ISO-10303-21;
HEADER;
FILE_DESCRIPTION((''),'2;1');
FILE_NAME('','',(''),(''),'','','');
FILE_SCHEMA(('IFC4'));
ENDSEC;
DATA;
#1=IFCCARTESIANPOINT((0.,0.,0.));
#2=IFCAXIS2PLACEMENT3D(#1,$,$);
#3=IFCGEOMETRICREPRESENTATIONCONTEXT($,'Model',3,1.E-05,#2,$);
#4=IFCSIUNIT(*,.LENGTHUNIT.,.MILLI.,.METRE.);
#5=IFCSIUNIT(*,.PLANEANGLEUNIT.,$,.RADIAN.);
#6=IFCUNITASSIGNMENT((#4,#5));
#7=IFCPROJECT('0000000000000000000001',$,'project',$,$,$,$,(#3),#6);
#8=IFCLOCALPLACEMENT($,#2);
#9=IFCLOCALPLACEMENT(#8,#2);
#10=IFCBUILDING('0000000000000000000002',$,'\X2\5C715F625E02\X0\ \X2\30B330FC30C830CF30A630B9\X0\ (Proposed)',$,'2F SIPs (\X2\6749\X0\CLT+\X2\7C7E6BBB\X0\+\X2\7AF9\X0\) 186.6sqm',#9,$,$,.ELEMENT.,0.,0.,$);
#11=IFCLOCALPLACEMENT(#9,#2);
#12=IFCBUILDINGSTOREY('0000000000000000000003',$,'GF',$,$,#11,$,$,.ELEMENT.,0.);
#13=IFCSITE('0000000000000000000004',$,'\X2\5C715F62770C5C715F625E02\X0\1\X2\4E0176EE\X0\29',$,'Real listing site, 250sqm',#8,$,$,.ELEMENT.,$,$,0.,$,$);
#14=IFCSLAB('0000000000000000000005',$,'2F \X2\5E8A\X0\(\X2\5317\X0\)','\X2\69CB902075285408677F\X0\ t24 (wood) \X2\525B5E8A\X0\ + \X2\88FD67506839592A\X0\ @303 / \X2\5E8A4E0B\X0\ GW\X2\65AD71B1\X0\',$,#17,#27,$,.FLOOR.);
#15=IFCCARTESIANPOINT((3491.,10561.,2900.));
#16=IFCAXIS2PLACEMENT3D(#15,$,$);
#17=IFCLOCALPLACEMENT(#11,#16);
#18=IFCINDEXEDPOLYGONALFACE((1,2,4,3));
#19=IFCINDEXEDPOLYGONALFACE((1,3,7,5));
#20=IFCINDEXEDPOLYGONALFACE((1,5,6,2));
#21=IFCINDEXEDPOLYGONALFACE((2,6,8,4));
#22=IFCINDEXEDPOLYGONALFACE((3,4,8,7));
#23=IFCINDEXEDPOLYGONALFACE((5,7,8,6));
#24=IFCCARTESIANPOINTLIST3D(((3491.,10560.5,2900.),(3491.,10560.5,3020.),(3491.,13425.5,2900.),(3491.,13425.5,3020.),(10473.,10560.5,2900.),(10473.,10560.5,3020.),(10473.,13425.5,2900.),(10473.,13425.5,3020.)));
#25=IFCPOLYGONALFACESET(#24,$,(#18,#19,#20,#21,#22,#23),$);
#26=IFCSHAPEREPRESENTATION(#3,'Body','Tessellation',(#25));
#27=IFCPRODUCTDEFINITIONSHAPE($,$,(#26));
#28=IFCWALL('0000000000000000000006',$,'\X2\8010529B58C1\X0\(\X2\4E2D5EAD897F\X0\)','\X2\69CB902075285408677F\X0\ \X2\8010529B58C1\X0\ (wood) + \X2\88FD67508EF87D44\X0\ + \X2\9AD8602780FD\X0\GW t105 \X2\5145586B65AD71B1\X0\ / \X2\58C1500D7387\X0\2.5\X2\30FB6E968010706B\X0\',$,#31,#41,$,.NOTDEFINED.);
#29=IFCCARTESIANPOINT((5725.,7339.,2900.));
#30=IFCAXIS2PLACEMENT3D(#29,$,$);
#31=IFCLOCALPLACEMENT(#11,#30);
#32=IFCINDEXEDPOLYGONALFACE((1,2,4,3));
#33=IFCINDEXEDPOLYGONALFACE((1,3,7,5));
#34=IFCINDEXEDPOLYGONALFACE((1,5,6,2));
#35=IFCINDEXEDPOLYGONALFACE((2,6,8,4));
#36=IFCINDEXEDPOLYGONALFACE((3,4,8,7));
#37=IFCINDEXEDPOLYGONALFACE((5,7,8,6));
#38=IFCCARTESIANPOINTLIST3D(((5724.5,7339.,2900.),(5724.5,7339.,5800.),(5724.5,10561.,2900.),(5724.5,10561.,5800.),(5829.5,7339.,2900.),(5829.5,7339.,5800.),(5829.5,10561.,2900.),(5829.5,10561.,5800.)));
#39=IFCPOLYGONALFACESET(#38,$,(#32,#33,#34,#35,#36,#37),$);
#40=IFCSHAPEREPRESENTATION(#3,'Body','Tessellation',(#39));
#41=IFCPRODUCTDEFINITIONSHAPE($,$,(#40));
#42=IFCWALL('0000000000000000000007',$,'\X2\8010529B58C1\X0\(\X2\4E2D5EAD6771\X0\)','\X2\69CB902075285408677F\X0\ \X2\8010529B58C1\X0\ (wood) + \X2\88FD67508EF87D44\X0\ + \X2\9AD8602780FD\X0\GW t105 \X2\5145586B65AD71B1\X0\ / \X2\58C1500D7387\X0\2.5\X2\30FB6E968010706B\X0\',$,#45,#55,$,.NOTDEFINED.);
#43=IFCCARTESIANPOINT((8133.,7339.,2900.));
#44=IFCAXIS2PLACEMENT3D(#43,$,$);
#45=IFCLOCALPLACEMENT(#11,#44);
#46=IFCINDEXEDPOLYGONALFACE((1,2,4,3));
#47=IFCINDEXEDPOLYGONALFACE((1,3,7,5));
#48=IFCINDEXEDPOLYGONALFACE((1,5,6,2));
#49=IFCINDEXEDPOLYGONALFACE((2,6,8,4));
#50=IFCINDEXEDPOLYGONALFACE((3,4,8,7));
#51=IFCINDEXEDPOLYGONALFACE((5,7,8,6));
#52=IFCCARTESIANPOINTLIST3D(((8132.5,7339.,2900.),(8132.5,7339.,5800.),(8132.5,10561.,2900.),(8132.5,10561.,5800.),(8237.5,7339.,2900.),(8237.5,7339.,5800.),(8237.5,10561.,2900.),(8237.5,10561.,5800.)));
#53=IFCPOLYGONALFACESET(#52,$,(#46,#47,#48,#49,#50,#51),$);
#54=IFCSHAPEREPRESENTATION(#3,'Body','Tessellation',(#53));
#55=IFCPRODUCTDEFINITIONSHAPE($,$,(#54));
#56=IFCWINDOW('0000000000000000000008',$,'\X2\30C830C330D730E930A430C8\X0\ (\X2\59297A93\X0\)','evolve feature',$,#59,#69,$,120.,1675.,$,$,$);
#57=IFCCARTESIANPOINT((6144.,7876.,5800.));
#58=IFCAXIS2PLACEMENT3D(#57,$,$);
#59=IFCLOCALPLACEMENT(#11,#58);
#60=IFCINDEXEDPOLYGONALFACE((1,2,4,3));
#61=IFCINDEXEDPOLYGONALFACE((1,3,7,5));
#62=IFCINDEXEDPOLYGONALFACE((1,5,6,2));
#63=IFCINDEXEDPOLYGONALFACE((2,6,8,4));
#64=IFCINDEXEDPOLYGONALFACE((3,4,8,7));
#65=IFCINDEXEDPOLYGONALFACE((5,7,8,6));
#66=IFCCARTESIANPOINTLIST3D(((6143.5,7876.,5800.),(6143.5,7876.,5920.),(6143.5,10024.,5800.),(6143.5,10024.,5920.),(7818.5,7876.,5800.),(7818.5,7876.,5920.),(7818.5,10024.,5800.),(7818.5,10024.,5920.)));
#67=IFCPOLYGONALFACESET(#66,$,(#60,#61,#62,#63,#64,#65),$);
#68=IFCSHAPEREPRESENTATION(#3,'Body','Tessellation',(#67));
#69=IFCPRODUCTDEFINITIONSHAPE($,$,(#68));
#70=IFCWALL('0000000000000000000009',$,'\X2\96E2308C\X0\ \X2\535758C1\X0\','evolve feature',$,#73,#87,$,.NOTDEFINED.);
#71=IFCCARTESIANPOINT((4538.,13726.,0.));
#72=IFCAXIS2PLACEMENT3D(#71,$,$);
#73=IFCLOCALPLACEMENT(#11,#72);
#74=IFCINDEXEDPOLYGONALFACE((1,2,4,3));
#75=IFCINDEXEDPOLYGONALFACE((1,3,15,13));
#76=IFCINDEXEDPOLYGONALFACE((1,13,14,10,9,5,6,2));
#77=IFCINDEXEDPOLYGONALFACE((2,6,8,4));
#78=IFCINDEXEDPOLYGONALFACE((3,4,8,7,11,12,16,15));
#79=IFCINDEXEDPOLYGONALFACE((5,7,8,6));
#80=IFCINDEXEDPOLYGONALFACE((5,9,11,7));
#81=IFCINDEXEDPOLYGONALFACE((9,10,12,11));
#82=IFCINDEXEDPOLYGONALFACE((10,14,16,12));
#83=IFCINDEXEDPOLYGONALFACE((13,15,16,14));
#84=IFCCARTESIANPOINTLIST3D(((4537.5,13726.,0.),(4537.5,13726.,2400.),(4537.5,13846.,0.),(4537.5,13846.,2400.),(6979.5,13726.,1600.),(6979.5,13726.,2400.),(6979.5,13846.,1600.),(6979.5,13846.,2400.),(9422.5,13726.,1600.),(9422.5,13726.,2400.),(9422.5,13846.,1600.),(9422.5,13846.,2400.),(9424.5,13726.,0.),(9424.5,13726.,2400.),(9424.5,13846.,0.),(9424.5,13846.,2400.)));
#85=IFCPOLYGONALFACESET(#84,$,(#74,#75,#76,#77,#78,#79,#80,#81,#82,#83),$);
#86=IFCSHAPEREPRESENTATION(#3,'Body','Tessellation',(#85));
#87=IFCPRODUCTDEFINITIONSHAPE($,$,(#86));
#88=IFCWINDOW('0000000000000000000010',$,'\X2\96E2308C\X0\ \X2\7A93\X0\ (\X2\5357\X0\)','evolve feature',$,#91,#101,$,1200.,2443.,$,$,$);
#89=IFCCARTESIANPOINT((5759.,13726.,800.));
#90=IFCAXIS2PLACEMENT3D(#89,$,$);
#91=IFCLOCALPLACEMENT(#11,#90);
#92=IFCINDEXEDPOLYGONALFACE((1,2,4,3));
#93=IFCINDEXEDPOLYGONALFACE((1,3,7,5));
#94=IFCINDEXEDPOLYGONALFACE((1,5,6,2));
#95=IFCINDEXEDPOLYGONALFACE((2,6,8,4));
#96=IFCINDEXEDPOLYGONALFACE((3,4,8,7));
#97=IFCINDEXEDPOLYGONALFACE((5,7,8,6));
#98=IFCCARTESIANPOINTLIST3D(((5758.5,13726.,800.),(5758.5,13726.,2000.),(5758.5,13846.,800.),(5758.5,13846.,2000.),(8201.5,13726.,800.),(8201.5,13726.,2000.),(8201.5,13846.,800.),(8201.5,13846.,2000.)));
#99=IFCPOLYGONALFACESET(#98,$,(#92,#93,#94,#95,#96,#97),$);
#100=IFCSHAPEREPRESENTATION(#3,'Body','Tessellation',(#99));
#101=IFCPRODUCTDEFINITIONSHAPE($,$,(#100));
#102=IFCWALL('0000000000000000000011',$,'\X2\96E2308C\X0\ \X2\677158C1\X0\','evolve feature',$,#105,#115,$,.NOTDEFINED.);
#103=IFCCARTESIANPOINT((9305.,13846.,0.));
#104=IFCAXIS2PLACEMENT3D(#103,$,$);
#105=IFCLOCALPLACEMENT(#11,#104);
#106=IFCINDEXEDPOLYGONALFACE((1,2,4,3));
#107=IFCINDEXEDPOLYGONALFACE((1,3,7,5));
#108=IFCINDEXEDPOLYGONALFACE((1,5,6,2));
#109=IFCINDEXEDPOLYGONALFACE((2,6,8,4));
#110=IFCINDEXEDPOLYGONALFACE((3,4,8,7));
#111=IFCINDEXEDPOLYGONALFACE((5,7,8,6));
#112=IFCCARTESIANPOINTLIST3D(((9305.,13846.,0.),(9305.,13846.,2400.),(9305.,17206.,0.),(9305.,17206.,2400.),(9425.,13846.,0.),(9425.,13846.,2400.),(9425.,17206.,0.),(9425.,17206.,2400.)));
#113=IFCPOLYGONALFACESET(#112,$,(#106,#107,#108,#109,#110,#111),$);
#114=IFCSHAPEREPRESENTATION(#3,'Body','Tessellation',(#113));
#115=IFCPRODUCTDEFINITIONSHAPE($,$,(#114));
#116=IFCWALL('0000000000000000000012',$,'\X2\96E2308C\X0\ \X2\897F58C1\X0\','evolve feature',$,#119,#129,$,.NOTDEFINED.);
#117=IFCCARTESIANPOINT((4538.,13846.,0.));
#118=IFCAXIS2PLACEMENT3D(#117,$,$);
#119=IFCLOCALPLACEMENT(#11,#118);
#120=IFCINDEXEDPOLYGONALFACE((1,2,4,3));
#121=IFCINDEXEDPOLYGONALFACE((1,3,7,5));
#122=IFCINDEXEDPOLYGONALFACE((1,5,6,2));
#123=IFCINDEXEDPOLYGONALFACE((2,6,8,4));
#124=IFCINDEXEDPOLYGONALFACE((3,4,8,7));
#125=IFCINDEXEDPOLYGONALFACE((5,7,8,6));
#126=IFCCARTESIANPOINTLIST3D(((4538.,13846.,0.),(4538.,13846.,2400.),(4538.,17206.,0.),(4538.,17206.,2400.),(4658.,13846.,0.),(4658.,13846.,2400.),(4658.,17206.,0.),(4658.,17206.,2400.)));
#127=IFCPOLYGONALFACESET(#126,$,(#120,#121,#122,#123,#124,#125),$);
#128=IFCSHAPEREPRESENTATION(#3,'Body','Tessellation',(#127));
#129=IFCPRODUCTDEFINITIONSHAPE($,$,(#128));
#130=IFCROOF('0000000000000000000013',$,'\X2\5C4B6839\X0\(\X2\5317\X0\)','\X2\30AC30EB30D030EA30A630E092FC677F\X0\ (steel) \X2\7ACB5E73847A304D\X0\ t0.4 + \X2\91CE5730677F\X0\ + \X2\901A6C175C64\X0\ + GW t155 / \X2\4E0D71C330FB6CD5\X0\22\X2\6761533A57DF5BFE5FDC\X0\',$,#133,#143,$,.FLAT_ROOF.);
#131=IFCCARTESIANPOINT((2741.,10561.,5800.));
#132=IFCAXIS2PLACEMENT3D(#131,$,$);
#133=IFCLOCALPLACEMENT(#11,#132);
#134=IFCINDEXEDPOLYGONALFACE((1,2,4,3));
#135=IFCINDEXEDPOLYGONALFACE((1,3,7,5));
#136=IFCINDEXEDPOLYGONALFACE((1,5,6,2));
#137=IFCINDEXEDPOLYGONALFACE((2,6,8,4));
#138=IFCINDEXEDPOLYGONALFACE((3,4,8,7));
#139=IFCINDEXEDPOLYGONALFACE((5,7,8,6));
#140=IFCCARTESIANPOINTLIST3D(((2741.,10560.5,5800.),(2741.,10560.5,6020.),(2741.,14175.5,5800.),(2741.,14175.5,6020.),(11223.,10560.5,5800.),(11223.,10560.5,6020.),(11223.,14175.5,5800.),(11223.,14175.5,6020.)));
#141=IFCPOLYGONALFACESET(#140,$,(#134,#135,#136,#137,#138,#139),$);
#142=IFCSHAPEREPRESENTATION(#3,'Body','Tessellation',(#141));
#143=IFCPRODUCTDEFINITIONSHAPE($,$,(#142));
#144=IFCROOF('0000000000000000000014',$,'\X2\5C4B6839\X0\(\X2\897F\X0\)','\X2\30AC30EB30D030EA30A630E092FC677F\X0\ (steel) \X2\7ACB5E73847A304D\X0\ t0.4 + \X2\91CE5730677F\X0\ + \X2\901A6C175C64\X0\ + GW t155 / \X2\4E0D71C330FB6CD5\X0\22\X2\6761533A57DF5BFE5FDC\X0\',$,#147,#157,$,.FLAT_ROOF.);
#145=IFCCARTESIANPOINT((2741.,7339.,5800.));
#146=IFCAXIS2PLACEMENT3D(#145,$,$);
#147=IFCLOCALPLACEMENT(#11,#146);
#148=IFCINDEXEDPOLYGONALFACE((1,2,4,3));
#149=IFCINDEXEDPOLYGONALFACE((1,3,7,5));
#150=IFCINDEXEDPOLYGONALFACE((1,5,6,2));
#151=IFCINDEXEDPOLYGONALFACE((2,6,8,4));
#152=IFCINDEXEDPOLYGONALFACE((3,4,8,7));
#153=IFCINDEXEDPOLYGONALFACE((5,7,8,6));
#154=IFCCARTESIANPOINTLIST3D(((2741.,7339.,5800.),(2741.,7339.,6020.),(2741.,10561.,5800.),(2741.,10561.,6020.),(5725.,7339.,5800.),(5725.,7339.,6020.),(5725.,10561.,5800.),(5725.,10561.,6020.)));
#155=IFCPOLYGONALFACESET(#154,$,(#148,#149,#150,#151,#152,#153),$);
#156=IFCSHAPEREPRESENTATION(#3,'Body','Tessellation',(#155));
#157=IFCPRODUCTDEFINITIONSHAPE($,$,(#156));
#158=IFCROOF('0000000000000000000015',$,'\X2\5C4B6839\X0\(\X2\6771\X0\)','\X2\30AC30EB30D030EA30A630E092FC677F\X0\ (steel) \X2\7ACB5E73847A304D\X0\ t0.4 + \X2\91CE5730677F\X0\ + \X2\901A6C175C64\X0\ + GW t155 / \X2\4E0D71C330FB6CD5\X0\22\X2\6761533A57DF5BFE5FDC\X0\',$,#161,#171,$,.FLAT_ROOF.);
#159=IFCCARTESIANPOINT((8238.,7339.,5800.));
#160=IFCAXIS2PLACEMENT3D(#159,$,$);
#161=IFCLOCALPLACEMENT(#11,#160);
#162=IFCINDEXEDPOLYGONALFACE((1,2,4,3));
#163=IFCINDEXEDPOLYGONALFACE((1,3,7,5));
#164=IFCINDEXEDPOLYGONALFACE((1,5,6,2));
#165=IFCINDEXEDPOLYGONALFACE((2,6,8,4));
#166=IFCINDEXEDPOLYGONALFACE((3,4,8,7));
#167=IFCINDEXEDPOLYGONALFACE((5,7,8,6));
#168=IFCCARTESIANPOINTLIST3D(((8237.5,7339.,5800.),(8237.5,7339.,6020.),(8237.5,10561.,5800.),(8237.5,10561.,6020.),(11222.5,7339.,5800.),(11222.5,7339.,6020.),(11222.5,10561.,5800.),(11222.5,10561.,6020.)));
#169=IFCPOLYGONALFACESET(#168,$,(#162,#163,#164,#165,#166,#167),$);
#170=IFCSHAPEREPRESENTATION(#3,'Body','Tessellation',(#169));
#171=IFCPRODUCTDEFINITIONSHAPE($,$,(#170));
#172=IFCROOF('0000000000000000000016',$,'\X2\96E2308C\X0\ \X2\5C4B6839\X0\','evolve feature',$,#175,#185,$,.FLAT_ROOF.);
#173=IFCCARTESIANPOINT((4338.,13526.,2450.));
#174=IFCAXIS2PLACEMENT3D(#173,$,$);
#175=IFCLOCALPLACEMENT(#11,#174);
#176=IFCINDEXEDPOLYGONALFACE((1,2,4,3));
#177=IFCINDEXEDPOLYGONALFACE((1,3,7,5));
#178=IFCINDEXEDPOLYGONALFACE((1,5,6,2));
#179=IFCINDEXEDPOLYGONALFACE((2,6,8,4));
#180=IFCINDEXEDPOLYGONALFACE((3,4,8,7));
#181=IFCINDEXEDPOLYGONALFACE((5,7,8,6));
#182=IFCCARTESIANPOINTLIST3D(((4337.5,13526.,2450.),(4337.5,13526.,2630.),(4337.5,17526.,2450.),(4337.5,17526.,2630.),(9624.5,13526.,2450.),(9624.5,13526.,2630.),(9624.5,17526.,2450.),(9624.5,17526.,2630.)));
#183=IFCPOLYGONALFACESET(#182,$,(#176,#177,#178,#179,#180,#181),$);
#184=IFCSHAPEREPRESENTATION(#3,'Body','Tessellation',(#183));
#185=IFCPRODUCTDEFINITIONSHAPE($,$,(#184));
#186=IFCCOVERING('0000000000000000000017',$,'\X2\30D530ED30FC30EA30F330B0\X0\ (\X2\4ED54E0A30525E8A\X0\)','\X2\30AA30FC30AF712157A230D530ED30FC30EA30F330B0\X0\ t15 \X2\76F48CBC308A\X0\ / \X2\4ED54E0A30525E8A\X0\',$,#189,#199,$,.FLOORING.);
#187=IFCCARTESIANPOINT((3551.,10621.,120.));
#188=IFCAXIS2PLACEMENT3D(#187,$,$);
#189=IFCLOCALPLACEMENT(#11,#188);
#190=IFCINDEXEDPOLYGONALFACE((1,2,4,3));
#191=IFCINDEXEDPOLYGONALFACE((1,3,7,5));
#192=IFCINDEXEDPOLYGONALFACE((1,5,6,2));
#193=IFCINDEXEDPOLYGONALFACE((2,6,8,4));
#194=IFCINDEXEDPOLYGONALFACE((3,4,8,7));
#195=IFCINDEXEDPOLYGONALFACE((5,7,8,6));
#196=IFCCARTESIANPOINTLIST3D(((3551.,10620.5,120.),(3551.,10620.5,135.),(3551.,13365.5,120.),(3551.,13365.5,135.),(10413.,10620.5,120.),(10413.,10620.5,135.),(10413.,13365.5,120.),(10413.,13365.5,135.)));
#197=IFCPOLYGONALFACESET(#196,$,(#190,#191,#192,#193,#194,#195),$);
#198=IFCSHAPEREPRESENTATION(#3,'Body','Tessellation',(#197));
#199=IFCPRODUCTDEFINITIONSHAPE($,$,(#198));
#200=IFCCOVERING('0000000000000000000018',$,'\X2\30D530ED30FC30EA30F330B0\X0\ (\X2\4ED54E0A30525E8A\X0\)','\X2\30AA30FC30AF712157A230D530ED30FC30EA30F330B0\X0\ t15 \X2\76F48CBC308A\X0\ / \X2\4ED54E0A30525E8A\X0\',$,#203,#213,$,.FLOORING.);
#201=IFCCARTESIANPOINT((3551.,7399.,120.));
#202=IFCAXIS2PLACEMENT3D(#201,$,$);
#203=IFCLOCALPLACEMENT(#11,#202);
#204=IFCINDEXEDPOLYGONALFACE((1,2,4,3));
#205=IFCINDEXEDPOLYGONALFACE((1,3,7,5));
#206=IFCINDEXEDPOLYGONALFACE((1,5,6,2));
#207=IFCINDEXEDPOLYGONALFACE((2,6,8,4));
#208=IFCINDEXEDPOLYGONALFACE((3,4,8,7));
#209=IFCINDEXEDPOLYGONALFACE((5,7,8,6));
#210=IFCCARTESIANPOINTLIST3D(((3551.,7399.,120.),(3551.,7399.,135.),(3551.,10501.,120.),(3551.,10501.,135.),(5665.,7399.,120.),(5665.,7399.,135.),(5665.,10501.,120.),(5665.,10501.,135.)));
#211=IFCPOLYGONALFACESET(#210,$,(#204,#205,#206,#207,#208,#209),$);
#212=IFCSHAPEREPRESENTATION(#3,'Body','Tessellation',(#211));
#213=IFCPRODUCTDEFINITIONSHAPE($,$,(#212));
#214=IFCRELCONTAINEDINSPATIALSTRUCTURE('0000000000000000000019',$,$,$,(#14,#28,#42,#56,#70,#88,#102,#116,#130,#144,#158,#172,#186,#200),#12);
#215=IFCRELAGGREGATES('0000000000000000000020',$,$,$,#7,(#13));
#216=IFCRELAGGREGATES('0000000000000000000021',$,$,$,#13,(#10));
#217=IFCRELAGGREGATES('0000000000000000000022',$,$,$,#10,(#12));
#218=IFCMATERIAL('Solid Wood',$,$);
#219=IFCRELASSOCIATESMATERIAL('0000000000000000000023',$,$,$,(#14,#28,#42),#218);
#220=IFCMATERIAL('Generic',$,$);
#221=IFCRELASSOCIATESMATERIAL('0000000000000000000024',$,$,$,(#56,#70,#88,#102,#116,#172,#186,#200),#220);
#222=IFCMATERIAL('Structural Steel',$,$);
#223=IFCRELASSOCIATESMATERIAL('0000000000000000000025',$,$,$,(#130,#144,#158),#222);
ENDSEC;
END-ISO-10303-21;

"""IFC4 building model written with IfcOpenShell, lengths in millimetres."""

from ifc_helpers import new_model, si_unit, frame, frame_2d, origin, place, context, project, spatial, rectangle, extrude, material, element, fill, save


model = new_model("IFC4")

# Units and contexts
model_context = context("Model", 3, precision=1e-05, world=origin())
ifc_project = project(units=[si_unit("LENGTHUNIT", "METRE", prefix="MILLI"), si_unit("PLANEANGLEUNIT", "RADIAN")], contexts=[model_context])

# Site, building, storey
site_placement = place(None, origin())
site = spatial("IfcSite", under=ifc_project, at=site_placement, Name="山形県山形市1丁目29", ObjectType="Real listing site, 250sqm", CompositionType="ELEMENT", RefElevation=0.0)
building_placement = place(site_placement, origin())
building = spatial("IfcBuilding", under=site, at=building_placement, Name="山形市 コートハウス (Proposed)", ObjectType="2F SIPs (杉CLT+籾殻+竹) 186.6sqm", CompositionType="ELEMENT", ElevationOfRefHeight=0.0, ElevationOfTerrain=0.0)
storey_placement = place(building_placement, origin())
storey = spatial("IfcBuildingStorey", under=building, at=storey_placement, Name="GF", CompositionType="ELEMENT", Elevation=0.0)

# Slab
ifc_material_1 = material(Name="Solid Wood")
slab_1_placement = place(storey_placement, frame((3491.0, 10561.0, 2900.0)))
element("IfcSlab", 1, at=slab_1_placement, inside=storey, material=ifc_material_1, Name="2F 床(北)", Description="構造用合板 t24 (wood) 剛床 + 製材根太 @303 / 床下 GW断熱", PredefinedType="FLOOR", context=model_context, shape_type="SweptSolid", body=[
    extrude(rectangle(XDim=6982.0, YDim=2865.0, at=frame_2d((3491.0, 1432.0))), frame((3491.0, 10561.0, 2900.0)), (0.0, 0.0, 1.0), 120.0),
])
ifc_material_2 = material(Name="Generic")

# Walls
wall_1_placement = place(storey_placement, frame((5725.0, 7339.0, 2900.0)))
element("IfcWall", 2, at=wall_1_placement, inside=storey, material=ifc_material_1, Name="耐力壁(中庭西)", Description="構造用合板 耐力壁 (wood) + 製材軸組 + 高性能GW t105 充填断熱 / 壁倍率2.5・準耐火", PredefinedType="NOTDEFINED", context=model_context, shape_type="SweptSolid", body=[
    extrude(rectangle(XDim=105.0, YDim=3222.0, at=frame_2d((52.0, 1611.0))), frame((5725.0, 7339.0, 2900.0)), (0.0, 0.0, 1.0), 2900.0),
])
wall_2_placement = place(storey_placement, frame((8133.0, 7339.0, 2900.0)))
element("IfcWall", 3, at=wall_2_placement, inside=storey, material=ifc_material_1, Name="耐力壁(中庭東)", Description="構造用合板 耐力壁 (wood) + 製材軸組 + 高性能GW t105 充填断熱 / 壁倍率2.5・準耐火", PredefinedType="NOTDEFINED", context=model_context, shape_type="SweptSolid", body=[
    extrude(rectangle(XDim=105.0, YDim=3222.0, at=frame_2d((52.0, 1611.0))), frame((8133.0, 7339.0, 2900.0)), (0.0, 0.0, 1.0), 2900.0),
])

# Window
window_1_placement = place(storey_placement, frame((6144.0, 7876.0, 5800.0)))
element("IfcWindow", 4, at=window_1_placement, inside=storey, material=ifc_material_2, Name="トップライト (天窓)", Description="evolve feature", OverallHeight=120.0, OverallWidth=1675.0, context=model_context, shape_type="SweptSolid", body=[
    extrude(rectangle(XDim=1675.0, YDim=2148.0, at=frame_2d((837.0, 1074.0))), frame((6144.0, 7876.0, 5800.0)), (0.0, 0.0, 1.0), 120.0),
])

# Wall, opening, window
wall_3_placement = place(storey_placement, frame((4538.0, 13726.0, 0.0)))
wall_3 = element("IfcWall", 5, at=wall_3_placement, inside=storey, material=ifc_material_2, Name="離れ 南壁", Description="evolve feature", PredefinedType="NOTDEFINED", context=model_context, shape_type="SweptSolid", body=[
    extrude(rectangle(XDim=4887.0, YDim=120.0, at=frame_2d((2443.0, 60.0))), frame((4538.0, 13726.0, 0.0)), (0.0, 0.0, 1.0), 2400.0),
])
opening_1_placement = place(storey_placement, frame((5759.0, 13726.0, 800.0)))
opening_1 = element("IfcOpeningElement", 6, at=opening_1_placement, cuts=wall_3, PredefinedType="NOTDEFINED", context=model_context, shape_type="SweptSolid", body=[
    extrude(rectangle(XDim=2443.0, YDim=120.0, at=frame_2d((1221.0, 60.0))), frame((5759.0, 13726.0, 800.0)), (0.0, 0.0, 1.0), 1200.0),
])
window_2_placement = place(storey_placement, frame((5759.0, 13726.0, 800.0)))
window_2 = element("IfcWindow", 7, at=window_2_placement, inside=storey, material=ifc_material_2, Name="離れ 窓 (南)", Description="evolve feature", OverallHeight=1200.0, OverallWidth=2443.0, context=model_context, shape_type="SweptSolid", body=[
    extrude(rectangle(XDim=2443.0, YDim=120.0, at=frame_2d((1221.0, 60.0))), frame((5759.0, 13726.0, 800.0)), (0.0, 0.0, 1.0), 1200.0),
])
fill(opening_1, window_2)

# Walls
wall_4_placement = place(storey_placement, frame((9305.0, 13846.0, 0.0)))
element("IfcWall", 8, at=wall_4_placement, inside=storey, material=ifc_material_2, Name="離れ 東壁", Description="evolve feature", PredefinedType="NOTDEFINED", context=model_context, shape_type="SweptSolid", body=[
    extrude(rectangle(XDim=120.0, YDim=3360.0, at=frame_2d((60.0, 1680.0))), frame((9305.0, 13846.0, 0.0)), (0.0, 0.0, 1.0), 2400.0),
])
wall_5_placement = place(storey_placement, frame((4538.0, 13846.0, 0.0)))
element("IfcWall", 9, at=wall_5_placement, inside=storey, material=ifc_material_2, Name="離れ 西壁", Description="evolve feature", PredefinedType="NOTDEFINED", context=model_context, shape_type="SweptSolid", body=[
    extrude(rectangle(XDim=120.0, YDim=3360.0, at=frame_2d((60.0, 1680.0))), frame((4538.0, 13846.0, 0.0)), (0.0, 0.0, 1.0), 2400.0),
])

# Roofs
ifc_material_3 = material(Name="Structural Steel")
for number, where, name in (
    (10, (2741.0, 10561.0, 5800.0), "屋根(北)"),
):
    element("IfcRoof", number, at=place(storey_placement, frame(where)), inside=storey, material=ifc_material_3, Name=name, Description="ガルバリウム鋼板 (steel) 立平葺き t0.4 + 野地板 + 通気層 + GW t155 / 不燃・法22条区域対応", PredefinedType="FLAT_ROOF", context=model_context, shape_type="SweptSolid", body=[
        extrude(rectangle(XDim=8482.0, YDim=3615.0, at=frame_2d((4241.0, 1807.0))), frame((2741.0, 10561.0, 5800.0)), (0.0, 0.0, 1.0), 220.0),
    ])
roof_1_placement = place(storey_placement, frame((2741.0, 7339.0, 5800.0)))
element("IfcRoof", 11, at=roof_1_placement, inside=storey, material=ifc_material_3, Name="屋根(西)", Description="ガルバリウム鋼板 (steel) 立平葺き t0.4 + 野地板 + 通気層 + GW t155 / 不燃・法22条区域対応", PredefinedType="FLAT_ROOF", context=model_context, shape_type="SweptSolid", body=[
    extrude(rectangle(XDim=2984.0, YDim=3222.0, at=frame_2d((1492.0, 1611.0))), frame((2741.0, 7339.0, 5800.0)), (0.0, 0.0, 1.0), 220.0),
])
roof_2_placement = place(storey_placement, frame((8238.0, 7339.0, 5800.0)))
element("IfcRoof", 12, at=roof_2_placement, inside=storey, material=ifc_material_3, Name="屋根(東)", Description="ガルバリウム鋼板 (steel) 立平葺き t0.4 + 野地板 + 通気層 + GW t155 / 不燃・法22条区域対応", PredefinedType="FLAT_ROOF", context=model_context, shape_type="SweptSolid", body=[
    extrude(rectangle(XDim=2985.0, YDim=3222.0, at=frame_2d((1492.0, 1611.0))), frame((8238.0, 7339.0, 5800.0)), (0.0, 0.0, 1.0), 220.0),
])
roof_3_placement = place(storey_placement, frame((4338.0, 13526.0, 2450.0)))
element("IfcRoof", 13, at=roof_3_placement, inside=storey, material=ifc_material_2, Name="離れ 屋根", Description="evolve feature", PredefinedType="FLAT_ROOF", context=model_context, shape_type="SweptSolid", body=[
    extrude(rectangle(XDim=5287.0, YDim=4000.0, at=frame_2d((2643.0, 2000.0))), frame((4338.0, 13526.0, 2450.0)), (0.0, 0.0, 1.0), 180.0),
])

# Coverings
covering_1_placement = place(storey_placement, frame((3551.0, 10621.0, 120.0)))
element("IfcCovering", 14, at=covering_1_placement, inside=storey, material=ifc_material_2, Name="フローリング (仕上げ床)", Description="オーク無垢フローリング t15 直貼り / 仕上げ床", PredefinedType="FLOORING", context=model_context, shape_type="SweptSolid", body=[
    extrude(rectangle(XDim=6862.0, YDim=2745.0, at=frame_2d((3431.0, 1372.0))), frame((3551.0, 10621.0, 120.0)), (0.0, 0.0, 1.0), 15.0),
])
covering_2_placement = place(storey_placement, frame((3551.0, 7399.0, 120.0)))
element("IfcCovering", 15, at=covering_2_placement, inside=storey, material=ifc_material_2, Name="フローリング (仕上げ床)", Description="オーク無垢フローリング t15 直貼り / 仕上げ床", PredefinedType="FLOORING", context=model_context, shape_type="SweptSolid", body=[
    extrude(rectangle(XDim=2114.0, YDim=3102.0, at=frame_2d((1057.0, 1551.0))), frame((3551.0, 7399.0, 120.0)), (0.0, 0.0, 1.0), 15.0),
])

save(model, "model.ifc")
